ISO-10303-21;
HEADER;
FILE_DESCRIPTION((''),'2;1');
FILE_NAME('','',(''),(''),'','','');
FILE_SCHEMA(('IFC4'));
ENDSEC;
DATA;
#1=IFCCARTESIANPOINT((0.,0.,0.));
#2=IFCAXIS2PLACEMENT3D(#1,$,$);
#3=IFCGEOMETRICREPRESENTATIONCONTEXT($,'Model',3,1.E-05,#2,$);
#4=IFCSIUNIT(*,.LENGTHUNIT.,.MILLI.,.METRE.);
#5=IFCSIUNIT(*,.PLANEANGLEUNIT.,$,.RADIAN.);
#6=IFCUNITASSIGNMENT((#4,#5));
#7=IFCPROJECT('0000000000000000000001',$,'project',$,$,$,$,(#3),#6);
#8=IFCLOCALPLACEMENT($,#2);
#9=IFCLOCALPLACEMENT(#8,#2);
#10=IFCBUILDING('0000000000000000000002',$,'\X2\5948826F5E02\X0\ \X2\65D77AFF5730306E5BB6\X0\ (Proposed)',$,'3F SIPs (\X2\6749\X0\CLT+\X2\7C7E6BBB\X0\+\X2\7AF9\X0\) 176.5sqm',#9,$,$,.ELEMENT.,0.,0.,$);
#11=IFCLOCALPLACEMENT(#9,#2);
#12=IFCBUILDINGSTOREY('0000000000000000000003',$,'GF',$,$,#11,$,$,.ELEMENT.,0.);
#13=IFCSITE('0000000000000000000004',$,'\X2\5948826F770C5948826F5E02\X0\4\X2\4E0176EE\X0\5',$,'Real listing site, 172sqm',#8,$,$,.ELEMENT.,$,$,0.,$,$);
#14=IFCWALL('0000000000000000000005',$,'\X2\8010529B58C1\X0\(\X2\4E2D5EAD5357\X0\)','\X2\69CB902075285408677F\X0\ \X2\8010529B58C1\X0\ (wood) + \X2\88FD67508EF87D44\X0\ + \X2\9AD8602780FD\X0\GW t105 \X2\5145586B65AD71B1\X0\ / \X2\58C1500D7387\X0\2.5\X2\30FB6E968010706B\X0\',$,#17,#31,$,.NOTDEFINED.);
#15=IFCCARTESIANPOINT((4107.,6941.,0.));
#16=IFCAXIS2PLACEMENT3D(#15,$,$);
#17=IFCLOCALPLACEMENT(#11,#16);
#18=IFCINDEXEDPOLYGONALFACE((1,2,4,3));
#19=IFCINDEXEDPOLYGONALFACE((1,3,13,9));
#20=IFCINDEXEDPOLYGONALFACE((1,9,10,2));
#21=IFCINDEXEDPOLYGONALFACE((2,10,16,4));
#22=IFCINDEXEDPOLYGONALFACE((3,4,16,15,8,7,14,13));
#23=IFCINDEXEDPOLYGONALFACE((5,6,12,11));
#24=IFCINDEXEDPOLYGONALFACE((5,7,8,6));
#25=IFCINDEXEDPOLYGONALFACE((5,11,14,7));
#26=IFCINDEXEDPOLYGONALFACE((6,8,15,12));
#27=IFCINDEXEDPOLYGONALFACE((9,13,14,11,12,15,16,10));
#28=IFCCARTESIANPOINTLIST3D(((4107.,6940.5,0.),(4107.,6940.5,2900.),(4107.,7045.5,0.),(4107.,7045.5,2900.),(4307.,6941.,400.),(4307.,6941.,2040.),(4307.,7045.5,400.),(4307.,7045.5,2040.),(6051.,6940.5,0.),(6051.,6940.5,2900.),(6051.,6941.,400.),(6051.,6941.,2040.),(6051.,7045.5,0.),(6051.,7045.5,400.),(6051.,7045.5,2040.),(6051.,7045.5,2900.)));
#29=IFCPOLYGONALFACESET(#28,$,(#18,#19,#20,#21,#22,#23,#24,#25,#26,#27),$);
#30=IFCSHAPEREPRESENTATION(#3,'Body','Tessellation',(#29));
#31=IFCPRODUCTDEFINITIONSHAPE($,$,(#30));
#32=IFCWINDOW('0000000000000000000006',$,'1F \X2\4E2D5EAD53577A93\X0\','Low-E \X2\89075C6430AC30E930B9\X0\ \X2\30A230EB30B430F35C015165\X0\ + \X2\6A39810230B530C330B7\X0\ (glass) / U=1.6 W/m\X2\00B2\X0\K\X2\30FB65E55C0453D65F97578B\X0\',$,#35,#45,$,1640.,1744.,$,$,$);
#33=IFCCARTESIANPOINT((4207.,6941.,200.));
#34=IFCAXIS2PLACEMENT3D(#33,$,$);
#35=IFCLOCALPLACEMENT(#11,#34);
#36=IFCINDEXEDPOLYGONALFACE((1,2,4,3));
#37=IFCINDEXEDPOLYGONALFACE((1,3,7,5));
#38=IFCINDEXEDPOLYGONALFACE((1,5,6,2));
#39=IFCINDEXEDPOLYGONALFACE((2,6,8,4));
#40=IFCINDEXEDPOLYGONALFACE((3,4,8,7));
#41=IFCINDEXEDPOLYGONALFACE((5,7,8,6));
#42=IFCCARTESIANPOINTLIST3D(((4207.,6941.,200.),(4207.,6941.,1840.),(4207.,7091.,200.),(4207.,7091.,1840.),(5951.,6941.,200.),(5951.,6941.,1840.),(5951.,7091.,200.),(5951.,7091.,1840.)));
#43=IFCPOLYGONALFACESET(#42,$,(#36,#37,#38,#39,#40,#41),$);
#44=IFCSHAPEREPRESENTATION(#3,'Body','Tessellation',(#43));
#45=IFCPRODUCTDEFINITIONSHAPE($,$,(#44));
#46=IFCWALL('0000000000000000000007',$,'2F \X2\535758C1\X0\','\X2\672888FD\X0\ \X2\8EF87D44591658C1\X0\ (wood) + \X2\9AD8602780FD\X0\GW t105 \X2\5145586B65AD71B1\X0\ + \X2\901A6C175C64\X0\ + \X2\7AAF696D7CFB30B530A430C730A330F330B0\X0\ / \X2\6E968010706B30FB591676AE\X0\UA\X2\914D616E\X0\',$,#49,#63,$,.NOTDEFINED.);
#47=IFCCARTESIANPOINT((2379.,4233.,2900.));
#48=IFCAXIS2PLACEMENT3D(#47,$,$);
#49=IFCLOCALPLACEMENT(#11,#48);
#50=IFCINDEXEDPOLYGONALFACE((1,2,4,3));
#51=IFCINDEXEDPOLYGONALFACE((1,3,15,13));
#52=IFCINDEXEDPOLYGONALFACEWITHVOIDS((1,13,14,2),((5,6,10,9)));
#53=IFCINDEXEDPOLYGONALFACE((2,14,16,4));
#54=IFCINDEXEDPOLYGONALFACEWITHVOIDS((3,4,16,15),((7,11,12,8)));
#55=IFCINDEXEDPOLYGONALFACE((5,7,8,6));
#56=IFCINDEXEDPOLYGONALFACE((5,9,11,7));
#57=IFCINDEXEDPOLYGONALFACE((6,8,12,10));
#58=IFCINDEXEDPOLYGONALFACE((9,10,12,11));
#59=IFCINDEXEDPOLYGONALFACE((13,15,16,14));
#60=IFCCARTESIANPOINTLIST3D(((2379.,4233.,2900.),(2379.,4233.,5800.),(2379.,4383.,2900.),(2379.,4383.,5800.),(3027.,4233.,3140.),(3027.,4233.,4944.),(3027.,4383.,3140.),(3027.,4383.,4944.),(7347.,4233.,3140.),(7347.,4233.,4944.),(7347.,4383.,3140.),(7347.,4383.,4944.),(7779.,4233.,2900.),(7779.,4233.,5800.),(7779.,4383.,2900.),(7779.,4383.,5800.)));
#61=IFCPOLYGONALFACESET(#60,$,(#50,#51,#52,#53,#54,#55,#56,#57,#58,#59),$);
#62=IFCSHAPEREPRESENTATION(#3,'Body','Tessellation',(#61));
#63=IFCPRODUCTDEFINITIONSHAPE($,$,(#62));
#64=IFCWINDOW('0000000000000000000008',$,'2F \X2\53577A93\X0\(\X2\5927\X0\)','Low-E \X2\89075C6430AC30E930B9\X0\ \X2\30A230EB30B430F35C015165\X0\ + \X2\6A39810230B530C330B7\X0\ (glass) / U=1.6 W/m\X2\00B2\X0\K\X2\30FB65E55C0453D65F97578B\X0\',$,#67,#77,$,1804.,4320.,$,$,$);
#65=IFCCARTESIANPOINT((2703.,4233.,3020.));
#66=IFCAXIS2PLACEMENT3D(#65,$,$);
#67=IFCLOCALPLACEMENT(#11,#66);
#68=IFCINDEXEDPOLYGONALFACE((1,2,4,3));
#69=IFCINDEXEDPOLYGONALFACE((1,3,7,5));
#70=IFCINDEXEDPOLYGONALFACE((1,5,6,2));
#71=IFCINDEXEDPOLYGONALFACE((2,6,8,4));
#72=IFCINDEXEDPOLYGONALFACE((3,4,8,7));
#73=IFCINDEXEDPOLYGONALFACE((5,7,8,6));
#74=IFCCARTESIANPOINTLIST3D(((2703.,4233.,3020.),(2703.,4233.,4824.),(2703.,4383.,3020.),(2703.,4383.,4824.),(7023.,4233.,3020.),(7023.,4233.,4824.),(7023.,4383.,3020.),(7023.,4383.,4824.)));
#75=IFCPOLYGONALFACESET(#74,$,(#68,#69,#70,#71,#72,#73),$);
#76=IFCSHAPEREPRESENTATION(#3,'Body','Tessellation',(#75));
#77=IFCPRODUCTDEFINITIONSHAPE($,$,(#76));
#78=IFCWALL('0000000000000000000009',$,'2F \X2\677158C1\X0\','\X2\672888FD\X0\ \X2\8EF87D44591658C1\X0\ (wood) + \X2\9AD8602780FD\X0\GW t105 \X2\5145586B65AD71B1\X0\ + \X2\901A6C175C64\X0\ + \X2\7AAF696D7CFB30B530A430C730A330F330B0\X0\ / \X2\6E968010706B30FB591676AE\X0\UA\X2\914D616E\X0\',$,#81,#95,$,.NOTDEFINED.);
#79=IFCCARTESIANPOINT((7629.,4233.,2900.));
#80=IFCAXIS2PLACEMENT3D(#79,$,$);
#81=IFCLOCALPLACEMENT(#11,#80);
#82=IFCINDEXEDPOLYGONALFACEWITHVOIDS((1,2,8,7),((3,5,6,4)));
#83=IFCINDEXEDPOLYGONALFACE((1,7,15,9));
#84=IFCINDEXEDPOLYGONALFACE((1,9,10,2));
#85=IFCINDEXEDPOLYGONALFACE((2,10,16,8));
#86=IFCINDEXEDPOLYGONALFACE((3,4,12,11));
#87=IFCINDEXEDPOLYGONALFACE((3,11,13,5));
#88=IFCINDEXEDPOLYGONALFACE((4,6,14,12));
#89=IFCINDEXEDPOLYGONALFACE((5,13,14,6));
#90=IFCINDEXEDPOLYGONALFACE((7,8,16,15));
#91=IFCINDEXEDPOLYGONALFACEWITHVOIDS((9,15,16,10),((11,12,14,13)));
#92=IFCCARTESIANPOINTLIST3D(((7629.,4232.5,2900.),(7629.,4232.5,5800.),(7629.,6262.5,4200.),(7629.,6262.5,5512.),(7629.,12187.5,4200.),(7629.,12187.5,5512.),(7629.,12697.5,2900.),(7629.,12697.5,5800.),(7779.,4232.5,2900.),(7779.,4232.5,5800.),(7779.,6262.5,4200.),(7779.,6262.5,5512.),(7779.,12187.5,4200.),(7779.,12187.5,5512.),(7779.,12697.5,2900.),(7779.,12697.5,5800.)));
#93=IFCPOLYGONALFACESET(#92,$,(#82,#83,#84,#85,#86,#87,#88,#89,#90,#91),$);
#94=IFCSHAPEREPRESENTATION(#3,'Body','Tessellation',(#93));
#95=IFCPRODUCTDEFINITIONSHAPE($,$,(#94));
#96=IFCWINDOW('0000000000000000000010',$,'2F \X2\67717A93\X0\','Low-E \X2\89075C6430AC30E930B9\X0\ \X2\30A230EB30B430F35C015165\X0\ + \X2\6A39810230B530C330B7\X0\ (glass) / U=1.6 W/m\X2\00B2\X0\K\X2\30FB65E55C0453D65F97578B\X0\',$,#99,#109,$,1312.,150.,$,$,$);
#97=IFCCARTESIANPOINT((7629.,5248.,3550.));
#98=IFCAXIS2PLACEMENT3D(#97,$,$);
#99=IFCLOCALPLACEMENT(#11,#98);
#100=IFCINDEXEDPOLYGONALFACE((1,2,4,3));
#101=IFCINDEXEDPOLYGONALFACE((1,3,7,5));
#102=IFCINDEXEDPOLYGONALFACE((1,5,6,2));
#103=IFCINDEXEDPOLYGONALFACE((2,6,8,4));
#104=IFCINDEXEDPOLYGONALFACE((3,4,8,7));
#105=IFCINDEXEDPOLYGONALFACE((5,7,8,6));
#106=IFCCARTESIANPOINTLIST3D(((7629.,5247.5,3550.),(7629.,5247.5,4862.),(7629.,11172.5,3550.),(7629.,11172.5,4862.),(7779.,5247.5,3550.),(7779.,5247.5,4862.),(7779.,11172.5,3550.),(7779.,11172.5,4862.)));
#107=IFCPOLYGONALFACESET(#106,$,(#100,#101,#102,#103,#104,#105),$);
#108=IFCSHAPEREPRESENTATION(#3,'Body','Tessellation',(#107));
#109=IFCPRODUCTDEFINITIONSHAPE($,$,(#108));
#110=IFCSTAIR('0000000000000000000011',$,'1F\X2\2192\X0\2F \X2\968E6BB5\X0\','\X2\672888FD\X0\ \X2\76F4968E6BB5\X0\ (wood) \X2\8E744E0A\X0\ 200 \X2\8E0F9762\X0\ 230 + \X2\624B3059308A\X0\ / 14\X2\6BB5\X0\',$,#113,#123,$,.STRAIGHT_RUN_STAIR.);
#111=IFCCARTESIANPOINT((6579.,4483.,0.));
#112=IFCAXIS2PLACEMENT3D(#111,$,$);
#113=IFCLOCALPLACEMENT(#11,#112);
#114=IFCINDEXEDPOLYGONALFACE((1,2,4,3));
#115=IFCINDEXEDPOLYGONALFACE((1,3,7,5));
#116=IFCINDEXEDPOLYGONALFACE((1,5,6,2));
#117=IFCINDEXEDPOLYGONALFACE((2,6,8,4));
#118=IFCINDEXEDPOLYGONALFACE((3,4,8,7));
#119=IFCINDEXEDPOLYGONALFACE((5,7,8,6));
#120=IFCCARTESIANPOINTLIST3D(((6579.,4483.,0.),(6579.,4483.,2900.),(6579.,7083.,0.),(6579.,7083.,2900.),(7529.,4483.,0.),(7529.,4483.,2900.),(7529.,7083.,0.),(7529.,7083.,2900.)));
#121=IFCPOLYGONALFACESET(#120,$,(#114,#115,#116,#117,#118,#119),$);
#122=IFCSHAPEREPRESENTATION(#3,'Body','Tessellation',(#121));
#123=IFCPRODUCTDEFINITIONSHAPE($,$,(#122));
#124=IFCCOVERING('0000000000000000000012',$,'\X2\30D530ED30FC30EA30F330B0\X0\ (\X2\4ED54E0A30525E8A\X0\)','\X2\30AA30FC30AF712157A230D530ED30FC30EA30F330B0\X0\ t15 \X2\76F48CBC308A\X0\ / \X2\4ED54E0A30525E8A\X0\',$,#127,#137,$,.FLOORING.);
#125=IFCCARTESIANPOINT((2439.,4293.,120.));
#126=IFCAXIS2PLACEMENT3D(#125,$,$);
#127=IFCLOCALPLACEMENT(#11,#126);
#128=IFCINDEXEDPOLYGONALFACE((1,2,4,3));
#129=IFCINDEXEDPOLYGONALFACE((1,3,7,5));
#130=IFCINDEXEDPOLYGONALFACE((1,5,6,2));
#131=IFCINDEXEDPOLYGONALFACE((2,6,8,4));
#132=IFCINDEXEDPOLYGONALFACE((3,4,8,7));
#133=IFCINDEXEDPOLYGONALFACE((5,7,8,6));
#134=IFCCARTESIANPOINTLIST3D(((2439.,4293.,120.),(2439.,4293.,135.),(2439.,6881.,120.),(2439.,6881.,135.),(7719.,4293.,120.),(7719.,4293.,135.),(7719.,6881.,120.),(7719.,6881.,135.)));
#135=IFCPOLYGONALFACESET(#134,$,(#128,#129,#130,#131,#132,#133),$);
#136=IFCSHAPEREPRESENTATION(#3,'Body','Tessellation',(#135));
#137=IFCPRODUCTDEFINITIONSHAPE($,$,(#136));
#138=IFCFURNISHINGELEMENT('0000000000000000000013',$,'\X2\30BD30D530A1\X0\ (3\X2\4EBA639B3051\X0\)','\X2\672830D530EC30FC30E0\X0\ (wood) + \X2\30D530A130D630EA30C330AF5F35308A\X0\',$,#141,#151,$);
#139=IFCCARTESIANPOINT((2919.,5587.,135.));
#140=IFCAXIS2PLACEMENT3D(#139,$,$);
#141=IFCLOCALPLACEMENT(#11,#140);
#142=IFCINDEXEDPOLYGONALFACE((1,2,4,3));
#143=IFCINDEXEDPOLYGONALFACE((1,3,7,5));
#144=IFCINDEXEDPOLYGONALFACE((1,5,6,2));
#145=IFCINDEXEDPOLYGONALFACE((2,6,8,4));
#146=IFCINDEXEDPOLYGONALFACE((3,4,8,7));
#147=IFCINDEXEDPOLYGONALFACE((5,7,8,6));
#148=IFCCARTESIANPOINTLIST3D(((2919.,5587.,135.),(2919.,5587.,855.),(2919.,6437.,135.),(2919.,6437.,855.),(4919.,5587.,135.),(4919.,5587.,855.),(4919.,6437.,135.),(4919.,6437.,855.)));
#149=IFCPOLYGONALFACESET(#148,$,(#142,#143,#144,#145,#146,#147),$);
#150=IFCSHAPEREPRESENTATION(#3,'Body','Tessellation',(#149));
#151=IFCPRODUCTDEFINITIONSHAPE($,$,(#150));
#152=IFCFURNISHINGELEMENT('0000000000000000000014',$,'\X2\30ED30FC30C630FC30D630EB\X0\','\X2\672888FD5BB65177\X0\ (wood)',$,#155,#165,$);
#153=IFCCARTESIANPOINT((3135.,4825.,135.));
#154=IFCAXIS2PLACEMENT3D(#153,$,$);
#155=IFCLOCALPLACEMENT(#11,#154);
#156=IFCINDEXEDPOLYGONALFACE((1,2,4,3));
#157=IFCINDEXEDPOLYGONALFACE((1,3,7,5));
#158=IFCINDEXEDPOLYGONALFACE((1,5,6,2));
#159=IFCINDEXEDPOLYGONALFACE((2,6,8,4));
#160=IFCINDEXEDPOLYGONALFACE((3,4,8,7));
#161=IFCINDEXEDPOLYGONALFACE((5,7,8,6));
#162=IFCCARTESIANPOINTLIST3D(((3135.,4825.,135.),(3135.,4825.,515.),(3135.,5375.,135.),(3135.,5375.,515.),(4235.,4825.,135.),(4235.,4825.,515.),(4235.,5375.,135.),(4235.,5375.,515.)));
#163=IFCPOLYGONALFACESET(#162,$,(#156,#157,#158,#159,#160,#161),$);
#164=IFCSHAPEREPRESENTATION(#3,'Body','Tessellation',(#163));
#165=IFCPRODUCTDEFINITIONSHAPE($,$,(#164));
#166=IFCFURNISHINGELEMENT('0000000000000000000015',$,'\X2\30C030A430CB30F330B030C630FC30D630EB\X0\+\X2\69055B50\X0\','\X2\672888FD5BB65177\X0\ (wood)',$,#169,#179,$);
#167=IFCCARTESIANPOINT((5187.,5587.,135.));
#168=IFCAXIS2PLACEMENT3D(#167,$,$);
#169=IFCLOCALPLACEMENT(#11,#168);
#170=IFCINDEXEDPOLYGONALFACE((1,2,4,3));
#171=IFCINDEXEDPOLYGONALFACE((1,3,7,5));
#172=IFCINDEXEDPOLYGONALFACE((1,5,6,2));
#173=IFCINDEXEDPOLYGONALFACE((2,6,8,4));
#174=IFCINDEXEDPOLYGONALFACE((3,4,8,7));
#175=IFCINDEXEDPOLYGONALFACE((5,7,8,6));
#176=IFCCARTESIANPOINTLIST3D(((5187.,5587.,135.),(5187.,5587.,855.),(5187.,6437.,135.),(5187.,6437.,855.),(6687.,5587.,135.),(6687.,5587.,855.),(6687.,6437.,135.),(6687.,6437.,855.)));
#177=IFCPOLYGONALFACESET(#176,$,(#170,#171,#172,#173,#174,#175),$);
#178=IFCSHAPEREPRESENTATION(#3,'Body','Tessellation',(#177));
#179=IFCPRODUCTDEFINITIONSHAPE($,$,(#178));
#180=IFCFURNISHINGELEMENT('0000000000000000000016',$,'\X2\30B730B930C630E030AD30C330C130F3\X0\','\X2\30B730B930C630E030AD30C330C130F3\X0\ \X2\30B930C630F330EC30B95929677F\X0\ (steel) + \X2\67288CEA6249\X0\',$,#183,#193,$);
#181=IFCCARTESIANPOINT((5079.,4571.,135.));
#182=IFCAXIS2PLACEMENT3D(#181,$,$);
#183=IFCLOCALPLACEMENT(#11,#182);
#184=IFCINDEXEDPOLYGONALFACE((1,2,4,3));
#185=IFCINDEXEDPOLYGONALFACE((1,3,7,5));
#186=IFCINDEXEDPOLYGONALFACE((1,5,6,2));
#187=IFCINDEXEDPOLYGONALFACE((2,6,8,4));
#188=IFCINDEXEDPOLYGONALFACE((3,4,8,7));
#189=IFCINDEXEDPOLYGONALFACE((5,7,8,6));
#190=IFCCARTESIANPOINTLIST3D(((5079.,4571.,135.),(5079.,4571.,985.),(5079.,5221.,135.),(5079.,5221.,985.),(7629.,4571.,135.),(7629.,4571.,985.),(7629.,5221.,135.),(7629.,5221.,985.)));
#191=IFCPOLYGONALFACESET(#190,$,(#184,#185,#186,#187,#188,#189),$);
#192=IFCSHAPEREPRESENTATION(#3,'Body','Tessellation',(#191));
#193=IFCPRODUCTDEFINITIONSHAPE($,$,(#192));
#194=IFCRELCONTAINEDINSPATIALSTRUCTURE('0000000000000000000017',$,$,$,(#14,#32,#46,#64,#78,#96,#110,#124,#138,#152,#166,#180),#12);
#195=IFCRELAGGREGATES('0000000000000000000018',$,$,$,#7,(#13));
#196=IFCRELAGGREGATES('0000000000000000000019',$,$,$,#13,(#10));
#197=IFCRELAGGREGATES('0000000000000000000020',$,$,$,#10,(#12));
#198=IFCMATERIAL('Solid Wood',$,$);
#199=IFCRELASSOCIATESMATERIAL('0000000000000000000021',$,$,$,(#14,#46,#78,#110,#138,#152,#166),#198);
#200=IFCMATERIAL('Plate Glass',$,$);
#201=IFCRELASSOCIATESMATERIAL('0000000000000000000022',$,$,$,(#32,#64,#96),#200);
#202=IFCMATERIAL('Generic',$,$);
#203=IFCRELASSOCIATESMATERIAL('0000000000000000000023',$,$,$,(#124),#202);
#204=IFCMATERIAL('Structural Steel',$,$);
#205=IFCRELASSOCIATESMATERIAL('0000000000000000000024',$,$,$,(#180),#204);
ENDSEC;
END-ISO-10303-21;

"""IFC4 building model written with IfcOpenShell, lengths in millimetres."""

from ifc_helpers import new_model, si_unit, frame, frame_2d, origin, place, context, project, spatial, rectangle, extrude, material, element, fill, save


model = new_model("IFC4")

# Units and contexts
model_context = context("Model", 3, precision=1e-05, world=origin())
ifc_project = project(units=[si_unit("LENGTHUNIT", "METRE", prefix="MILLI"), si_unit("PLANEANGLEUNIT", "RADIAN")], contexts=[model_context])

# Site, building, storey
site_placement = place(None, origin())
site = spatial("IfcSite", under=ifc_project, at=site_placement, Name="奈良県奈良市4丁目5", ObjectType="Real listing site, 172sqm", CompositionType="ELEMENT", RefElevation=0.0)
building_placement = place(site_placement, origin())
building = spatial("IfcBuilding", under=site, at=building_placement, Name="奈良市 旗竿地の家 (Proposed)", ObjectType="3F SIPs (杉CLT+籾殻+竹) 176.5sqm", CompositionType="ELEMENT", ElevationOfRefHeight=0.0, ElevationOfTerrain=0.0)
storey_placement = place(building_placement, origin())
storey = spatial("IfcBuildingStorey", under=building, at=storey_placement, Name="GF", CompositionType="ELEMENT", Elevation=0.0)

# Shared definitions
ifc_material_1 = material(Name="Solid Wood")
ifc_material_2 = material(Name="Generic")

# Shared definitions
ifc_material_3 = material(Name="Plate Glass")

# Wall, opening, window
wall_1_placement = place(storey_placement, frame((4107.0, 6941.0, 0.0)))
wall_1 = element("IfcWall", 1, at=wall_1_placement, inside=storey, material=ifc_material_1, Name="耐力壁(中庭南)", Description="構造用合板 耐力壁 (wood) + 製材軸組 + 高性能GW t105 充填断熱 / 壁倍率2.5・準耐火", PredefinedType="NOTDEFINED", context=model_context, shape_type="SweptSolid", body=[
    extrude(rectangle(XDim=1944.0, YDim=105.0, at=frame_2d((972.0, 52.0))), frame((4107.0, 6941.0, 0.0)), (0.0, 0.0, 1.0), 2900.0),
])
opening_1_placement = place(storey_placement, frame((4207.0, 6941.0, 200.0)))
opening_1 = element("IfcOpeningElement", 2, at=opening_1_placement, cuts=wall_1, PredefinedType="NOTDEFINED", context=model_context, shape_type="SweptSolid", body=[
    extrude(rectangle(XDim=1744.0, YDim=150.0, at=frame_2d((872.0, 75.0))), frame((4207.0, 6941.0, 200.0)), (0.0, 0.0, 1.0), 1640.0),
])
window_1_placement = place(storey_placement, frame((4207.0, 6941.0, 200.0)))
window_1 = element("IfcWindow", 3, at=window_1_placement, inside=storey, material=ifc_material_3, Name="1F 中庭南窓", Description="Low-E 複層ガラス アルゴン封入 + 樹脂サッシ (glass) / U=1.6 W/m²K・日射取得型", OverallHeight=1640.0, OverallWidth=1744.0, context=model_context, shape_type="SweptSolid", body=[
    extrude(rectangle(XDim=1744.0, YDim=150.0, at=frame_2d((872.0, 75.0))), frame((4207.0, 6941.0, 200.0)), (0.0, 0.0, 1.0), 1640.0),
])
fill(opening_1, window_1)

# Walls, openings, windows
wall_2_placement = place(storey_placement, frame((2379.0, 4233.0, 2900.0)))
wall_2 = element("IfcWall", 4, at=wall_2_placement, inside=storey, material=ifc_material_1, Name="2F 南壁", Description="木製 軸組外壁 (wood) + 高性能GW t105 充填断熱 + 通気層 + 窯業系サイディング / 準耐火・外皮UA配慮", PredefinedType="NOTDEFINED", context=model_context, shape_type="SweptSolid", body=[
    extrude(rectangle(XDim=5400.0, YDim=150.0, at=frame_2d((2700.0, 75.0))), frame((2379.0, 4233.0, 2900.0)), (0.0, 0.0, 1.0), 2900.0),
])
opening_2_placement = place(storey_placement, frame((2703.0, 4233.0, 3020.0)))
opening_2 = element("IfcOpeningElement", 5, at=opening_2_placement, cuts=wall_2, PredefinedType="NOTDEFINED", context=model_context, shape_type="SweptSolid", body=[
    extrude(rectangle(XDim=4320.0, YDim=150.0, at=frame_2d((2160.0, 75.0))), frame((2703.0, 4233.0, 3020.0)), (0.0, 0.0, 1.0), 1804.0),
])
window_2_placement = place(storey_placement, frame((2703.0, 4233.0, 3020.0)))
window_2 = element("IfcWindow", 6, at=window_2_placement, inside=storey, material=ifc_material_3, Name="2F 南窓(大)", Description="Low-E 複層ガラス アルゴン封入 + 樹脂サッシ (glass) / U=1.6 W/m²K・日射取得型", OverallHeight=1804.0, OverallWidth=4320.0, context=model_context, shape_type="SweptSolid", body=[
    extrude(rectangle(XDim=4320.0, YDim=150.0, at=frame_2d((2160.0, 75.0))), frame((2703.0, 4233.0, 3020.0)), (0.0, 0.0, 1.0), 1804.0),
])
fill(opening_2, window_2)
wall_3_placement = place(storey_placement, frame((7629.0, 4233.0, 2900.0)))
wall_3 = element("IfcWall", 7, at=wall_3_placement, inside=storey, material=ifc_material_1, Name="2F 東壁", Description="木製 軸組外壁 (wood) + 高性能GW t105 充填断熱 + 通気層 + 窯業系サイディング / 準耐火・外皮UA配慮", PredefinedType="NOTDEFINED", context=model_context, shape_type="SweptSolid", body=[
    extrude(rectangle(XDim=150.0, YDim=8465.0, at=frame_2d((75.0, 4232.0))), frame((7629.0, 4233.0, 2900.0)), (0.0, 0.0, 1.0), 2900.0),
])
opening_3_placement = place(storey_placement, frame((7629.0, 5248.0, 3550.0)))
opening_3 = element("IfcOpeningElement", 8, at=opening_3_placement, cuts=wall_3, PredefinedType="NOTDEFINED", context=model_context, shape_type="SweptSolid", body=[
    extrude(rectangle(XDim=150.0, YDim=5925.0, at=frame_2d((75.0, 2962.0))), frame((7629.0, 5248.0, 3550.0)), (0.0, 0.0, 1.0), 1312.0),
])
window_3_placement = place(storey_placement, frame((7629.0, 5248.0, 3550.0)))
window_3 = element("IfcWindow", 9, at=window_3_placement, inside=storey, material=ifc_material_3, Name="2F 東窓", Description="Low-E 複層ガラス アルゴン封入 + 樹脂サッシ (glass) / U=1.6 W/m²K・日射取得型", OverallHeight=1312.0, OverallWidth=150.0, context=model_context, shape_type="SweptSolid", body=[
    extrude(rectangle(XDim=150.0, YDim=5925.0, at=frame_2d((75.0, 2962.0))), frame((7629.0, 5248.0, 3550.0)), (0.0, 0.0, 1.0), 1312.0),
])
fill(opening_3, window_3)

# Stair
stair_placement = place(storey_placement, frame((6579.0, 4483.0, 0.0)))
element("IfcStair", 10, at=stair_placement, inside=storey, material=ifc_material_1, Name="1F→2F 階段", Description="木製 直階段 (wood) 蹴上 200 踏面 230 + 手すり / 14段", PredefinedType="STRAIGHT_RUN_STAIR", context=model_context, shape_type="SweptSolid", body=[
    extrude(rectangle(XDim=950.0, YDim=2600.0, at=frame_2d((475.0, 1300.0))), frame((6579.0, 4483.0, 0.0)), (0.0, 0.0, 1.0), 2900.0),
])

# Covering
covering_placement = place(storey_placement, frame((2439.0, 4293.0, 120.0)))
element("IfcCovering", 11, at=covering_placement, inside=storey, material=ifc_material_2, Name="フローリング (仕上げ床)", Description="オーク無垢フローリング t15 直貼り / 仕上げ床", PredefinedType="FLOORING", context=model_context, shape_type="SweptSolid", body=[
    extrude(rectangle(XDim=5280.0, YDim=2588.0, at=frame_2d((2640.0, 1294.0))), frame((2439.0, 4293.0, 120.0)), (0.0, 0.0, 1.0), 15.0),
])

# Furnishing elements
furnishing_1_placement = place(storey_placement, frame((2919.0, 5587.0, 135.0)))
element("IfcFurnishingElement", 12, at=furnishing_1_placement, inside=storey, material=ifc_material_1, Name="ソファ (3人掛け)", Description="木フレーム (wood) + ファブリック張り", context=model_context, shape_type="SweptSolid", body=[
    extrude(rectangle(XDim=2000.0, YDim=850.0, at=frame_2d((1000.0, 425.0))), frame((2919.0, 5587.0, 135.0)), (0.0, 0.0, 1.0), 720.0),
])
furnishing_2_placement = place(storey_placement, frame((3135.0, 4825.0, 135.0)))
element("IfcFurnishingElement", 13, at=furnishing_2_placement, inside=storey, material=ifc_material_1, Name="ローテーブル", Description="木製家具 (wood)", context=model_context, shape_type="SweptSolid", body=[
    extrude(rectangle(XDim=1100.0, YDim=550.0, at=frame_2d((550.0, 275.0))), frame((3135.0, 4825.0, 135.0)), (0.0, 0.0, 1.0), 380.0),
])
furnishing_3_placement = place(storey_placement, frame((5187.0, 5587.0, 135.0)))
element("IfcFurnishingElement", 14, at=furnishing_3_placement, inside=storey, material=ifc_material_1, Name="ダイニングテーブル+椅子", Description="木製家具 (wood)", context=model_context, shape_type="SweptSolid", body=[
    extrude(rectangle(XDim=1500.0, YDim=850.0, at=frame_2d((750.0, 425.0))), frame((5187.0, 5587.0, 135.0)), (0.0, 0.0, 1.0), 720.0),
])
ifc_material_4 = material(Name="Structural Steel")
furnishing_4_placement = place(storey_placement, frame((5079.0, 4571.0, 135.0)))
element("IfcFurnishingElement", 15, at=furnishing_4_placement, inside=storey, material=ifc_material_4, Name="システムキッチン", Description="システムキッチン ステンレス天板 (steel) + 木質扉", context=model_context, shape_type="SweptSolid", body=[
    extrude(rectangle(XDim=2550.0, YDim=650.0, at=frame_2d((1275.0, 325.0))), frame((5079.0, 4571.0, 135.0)), (0.0, 0.0, 1.0), 850.0),
])

save(model, "model.ifc")
